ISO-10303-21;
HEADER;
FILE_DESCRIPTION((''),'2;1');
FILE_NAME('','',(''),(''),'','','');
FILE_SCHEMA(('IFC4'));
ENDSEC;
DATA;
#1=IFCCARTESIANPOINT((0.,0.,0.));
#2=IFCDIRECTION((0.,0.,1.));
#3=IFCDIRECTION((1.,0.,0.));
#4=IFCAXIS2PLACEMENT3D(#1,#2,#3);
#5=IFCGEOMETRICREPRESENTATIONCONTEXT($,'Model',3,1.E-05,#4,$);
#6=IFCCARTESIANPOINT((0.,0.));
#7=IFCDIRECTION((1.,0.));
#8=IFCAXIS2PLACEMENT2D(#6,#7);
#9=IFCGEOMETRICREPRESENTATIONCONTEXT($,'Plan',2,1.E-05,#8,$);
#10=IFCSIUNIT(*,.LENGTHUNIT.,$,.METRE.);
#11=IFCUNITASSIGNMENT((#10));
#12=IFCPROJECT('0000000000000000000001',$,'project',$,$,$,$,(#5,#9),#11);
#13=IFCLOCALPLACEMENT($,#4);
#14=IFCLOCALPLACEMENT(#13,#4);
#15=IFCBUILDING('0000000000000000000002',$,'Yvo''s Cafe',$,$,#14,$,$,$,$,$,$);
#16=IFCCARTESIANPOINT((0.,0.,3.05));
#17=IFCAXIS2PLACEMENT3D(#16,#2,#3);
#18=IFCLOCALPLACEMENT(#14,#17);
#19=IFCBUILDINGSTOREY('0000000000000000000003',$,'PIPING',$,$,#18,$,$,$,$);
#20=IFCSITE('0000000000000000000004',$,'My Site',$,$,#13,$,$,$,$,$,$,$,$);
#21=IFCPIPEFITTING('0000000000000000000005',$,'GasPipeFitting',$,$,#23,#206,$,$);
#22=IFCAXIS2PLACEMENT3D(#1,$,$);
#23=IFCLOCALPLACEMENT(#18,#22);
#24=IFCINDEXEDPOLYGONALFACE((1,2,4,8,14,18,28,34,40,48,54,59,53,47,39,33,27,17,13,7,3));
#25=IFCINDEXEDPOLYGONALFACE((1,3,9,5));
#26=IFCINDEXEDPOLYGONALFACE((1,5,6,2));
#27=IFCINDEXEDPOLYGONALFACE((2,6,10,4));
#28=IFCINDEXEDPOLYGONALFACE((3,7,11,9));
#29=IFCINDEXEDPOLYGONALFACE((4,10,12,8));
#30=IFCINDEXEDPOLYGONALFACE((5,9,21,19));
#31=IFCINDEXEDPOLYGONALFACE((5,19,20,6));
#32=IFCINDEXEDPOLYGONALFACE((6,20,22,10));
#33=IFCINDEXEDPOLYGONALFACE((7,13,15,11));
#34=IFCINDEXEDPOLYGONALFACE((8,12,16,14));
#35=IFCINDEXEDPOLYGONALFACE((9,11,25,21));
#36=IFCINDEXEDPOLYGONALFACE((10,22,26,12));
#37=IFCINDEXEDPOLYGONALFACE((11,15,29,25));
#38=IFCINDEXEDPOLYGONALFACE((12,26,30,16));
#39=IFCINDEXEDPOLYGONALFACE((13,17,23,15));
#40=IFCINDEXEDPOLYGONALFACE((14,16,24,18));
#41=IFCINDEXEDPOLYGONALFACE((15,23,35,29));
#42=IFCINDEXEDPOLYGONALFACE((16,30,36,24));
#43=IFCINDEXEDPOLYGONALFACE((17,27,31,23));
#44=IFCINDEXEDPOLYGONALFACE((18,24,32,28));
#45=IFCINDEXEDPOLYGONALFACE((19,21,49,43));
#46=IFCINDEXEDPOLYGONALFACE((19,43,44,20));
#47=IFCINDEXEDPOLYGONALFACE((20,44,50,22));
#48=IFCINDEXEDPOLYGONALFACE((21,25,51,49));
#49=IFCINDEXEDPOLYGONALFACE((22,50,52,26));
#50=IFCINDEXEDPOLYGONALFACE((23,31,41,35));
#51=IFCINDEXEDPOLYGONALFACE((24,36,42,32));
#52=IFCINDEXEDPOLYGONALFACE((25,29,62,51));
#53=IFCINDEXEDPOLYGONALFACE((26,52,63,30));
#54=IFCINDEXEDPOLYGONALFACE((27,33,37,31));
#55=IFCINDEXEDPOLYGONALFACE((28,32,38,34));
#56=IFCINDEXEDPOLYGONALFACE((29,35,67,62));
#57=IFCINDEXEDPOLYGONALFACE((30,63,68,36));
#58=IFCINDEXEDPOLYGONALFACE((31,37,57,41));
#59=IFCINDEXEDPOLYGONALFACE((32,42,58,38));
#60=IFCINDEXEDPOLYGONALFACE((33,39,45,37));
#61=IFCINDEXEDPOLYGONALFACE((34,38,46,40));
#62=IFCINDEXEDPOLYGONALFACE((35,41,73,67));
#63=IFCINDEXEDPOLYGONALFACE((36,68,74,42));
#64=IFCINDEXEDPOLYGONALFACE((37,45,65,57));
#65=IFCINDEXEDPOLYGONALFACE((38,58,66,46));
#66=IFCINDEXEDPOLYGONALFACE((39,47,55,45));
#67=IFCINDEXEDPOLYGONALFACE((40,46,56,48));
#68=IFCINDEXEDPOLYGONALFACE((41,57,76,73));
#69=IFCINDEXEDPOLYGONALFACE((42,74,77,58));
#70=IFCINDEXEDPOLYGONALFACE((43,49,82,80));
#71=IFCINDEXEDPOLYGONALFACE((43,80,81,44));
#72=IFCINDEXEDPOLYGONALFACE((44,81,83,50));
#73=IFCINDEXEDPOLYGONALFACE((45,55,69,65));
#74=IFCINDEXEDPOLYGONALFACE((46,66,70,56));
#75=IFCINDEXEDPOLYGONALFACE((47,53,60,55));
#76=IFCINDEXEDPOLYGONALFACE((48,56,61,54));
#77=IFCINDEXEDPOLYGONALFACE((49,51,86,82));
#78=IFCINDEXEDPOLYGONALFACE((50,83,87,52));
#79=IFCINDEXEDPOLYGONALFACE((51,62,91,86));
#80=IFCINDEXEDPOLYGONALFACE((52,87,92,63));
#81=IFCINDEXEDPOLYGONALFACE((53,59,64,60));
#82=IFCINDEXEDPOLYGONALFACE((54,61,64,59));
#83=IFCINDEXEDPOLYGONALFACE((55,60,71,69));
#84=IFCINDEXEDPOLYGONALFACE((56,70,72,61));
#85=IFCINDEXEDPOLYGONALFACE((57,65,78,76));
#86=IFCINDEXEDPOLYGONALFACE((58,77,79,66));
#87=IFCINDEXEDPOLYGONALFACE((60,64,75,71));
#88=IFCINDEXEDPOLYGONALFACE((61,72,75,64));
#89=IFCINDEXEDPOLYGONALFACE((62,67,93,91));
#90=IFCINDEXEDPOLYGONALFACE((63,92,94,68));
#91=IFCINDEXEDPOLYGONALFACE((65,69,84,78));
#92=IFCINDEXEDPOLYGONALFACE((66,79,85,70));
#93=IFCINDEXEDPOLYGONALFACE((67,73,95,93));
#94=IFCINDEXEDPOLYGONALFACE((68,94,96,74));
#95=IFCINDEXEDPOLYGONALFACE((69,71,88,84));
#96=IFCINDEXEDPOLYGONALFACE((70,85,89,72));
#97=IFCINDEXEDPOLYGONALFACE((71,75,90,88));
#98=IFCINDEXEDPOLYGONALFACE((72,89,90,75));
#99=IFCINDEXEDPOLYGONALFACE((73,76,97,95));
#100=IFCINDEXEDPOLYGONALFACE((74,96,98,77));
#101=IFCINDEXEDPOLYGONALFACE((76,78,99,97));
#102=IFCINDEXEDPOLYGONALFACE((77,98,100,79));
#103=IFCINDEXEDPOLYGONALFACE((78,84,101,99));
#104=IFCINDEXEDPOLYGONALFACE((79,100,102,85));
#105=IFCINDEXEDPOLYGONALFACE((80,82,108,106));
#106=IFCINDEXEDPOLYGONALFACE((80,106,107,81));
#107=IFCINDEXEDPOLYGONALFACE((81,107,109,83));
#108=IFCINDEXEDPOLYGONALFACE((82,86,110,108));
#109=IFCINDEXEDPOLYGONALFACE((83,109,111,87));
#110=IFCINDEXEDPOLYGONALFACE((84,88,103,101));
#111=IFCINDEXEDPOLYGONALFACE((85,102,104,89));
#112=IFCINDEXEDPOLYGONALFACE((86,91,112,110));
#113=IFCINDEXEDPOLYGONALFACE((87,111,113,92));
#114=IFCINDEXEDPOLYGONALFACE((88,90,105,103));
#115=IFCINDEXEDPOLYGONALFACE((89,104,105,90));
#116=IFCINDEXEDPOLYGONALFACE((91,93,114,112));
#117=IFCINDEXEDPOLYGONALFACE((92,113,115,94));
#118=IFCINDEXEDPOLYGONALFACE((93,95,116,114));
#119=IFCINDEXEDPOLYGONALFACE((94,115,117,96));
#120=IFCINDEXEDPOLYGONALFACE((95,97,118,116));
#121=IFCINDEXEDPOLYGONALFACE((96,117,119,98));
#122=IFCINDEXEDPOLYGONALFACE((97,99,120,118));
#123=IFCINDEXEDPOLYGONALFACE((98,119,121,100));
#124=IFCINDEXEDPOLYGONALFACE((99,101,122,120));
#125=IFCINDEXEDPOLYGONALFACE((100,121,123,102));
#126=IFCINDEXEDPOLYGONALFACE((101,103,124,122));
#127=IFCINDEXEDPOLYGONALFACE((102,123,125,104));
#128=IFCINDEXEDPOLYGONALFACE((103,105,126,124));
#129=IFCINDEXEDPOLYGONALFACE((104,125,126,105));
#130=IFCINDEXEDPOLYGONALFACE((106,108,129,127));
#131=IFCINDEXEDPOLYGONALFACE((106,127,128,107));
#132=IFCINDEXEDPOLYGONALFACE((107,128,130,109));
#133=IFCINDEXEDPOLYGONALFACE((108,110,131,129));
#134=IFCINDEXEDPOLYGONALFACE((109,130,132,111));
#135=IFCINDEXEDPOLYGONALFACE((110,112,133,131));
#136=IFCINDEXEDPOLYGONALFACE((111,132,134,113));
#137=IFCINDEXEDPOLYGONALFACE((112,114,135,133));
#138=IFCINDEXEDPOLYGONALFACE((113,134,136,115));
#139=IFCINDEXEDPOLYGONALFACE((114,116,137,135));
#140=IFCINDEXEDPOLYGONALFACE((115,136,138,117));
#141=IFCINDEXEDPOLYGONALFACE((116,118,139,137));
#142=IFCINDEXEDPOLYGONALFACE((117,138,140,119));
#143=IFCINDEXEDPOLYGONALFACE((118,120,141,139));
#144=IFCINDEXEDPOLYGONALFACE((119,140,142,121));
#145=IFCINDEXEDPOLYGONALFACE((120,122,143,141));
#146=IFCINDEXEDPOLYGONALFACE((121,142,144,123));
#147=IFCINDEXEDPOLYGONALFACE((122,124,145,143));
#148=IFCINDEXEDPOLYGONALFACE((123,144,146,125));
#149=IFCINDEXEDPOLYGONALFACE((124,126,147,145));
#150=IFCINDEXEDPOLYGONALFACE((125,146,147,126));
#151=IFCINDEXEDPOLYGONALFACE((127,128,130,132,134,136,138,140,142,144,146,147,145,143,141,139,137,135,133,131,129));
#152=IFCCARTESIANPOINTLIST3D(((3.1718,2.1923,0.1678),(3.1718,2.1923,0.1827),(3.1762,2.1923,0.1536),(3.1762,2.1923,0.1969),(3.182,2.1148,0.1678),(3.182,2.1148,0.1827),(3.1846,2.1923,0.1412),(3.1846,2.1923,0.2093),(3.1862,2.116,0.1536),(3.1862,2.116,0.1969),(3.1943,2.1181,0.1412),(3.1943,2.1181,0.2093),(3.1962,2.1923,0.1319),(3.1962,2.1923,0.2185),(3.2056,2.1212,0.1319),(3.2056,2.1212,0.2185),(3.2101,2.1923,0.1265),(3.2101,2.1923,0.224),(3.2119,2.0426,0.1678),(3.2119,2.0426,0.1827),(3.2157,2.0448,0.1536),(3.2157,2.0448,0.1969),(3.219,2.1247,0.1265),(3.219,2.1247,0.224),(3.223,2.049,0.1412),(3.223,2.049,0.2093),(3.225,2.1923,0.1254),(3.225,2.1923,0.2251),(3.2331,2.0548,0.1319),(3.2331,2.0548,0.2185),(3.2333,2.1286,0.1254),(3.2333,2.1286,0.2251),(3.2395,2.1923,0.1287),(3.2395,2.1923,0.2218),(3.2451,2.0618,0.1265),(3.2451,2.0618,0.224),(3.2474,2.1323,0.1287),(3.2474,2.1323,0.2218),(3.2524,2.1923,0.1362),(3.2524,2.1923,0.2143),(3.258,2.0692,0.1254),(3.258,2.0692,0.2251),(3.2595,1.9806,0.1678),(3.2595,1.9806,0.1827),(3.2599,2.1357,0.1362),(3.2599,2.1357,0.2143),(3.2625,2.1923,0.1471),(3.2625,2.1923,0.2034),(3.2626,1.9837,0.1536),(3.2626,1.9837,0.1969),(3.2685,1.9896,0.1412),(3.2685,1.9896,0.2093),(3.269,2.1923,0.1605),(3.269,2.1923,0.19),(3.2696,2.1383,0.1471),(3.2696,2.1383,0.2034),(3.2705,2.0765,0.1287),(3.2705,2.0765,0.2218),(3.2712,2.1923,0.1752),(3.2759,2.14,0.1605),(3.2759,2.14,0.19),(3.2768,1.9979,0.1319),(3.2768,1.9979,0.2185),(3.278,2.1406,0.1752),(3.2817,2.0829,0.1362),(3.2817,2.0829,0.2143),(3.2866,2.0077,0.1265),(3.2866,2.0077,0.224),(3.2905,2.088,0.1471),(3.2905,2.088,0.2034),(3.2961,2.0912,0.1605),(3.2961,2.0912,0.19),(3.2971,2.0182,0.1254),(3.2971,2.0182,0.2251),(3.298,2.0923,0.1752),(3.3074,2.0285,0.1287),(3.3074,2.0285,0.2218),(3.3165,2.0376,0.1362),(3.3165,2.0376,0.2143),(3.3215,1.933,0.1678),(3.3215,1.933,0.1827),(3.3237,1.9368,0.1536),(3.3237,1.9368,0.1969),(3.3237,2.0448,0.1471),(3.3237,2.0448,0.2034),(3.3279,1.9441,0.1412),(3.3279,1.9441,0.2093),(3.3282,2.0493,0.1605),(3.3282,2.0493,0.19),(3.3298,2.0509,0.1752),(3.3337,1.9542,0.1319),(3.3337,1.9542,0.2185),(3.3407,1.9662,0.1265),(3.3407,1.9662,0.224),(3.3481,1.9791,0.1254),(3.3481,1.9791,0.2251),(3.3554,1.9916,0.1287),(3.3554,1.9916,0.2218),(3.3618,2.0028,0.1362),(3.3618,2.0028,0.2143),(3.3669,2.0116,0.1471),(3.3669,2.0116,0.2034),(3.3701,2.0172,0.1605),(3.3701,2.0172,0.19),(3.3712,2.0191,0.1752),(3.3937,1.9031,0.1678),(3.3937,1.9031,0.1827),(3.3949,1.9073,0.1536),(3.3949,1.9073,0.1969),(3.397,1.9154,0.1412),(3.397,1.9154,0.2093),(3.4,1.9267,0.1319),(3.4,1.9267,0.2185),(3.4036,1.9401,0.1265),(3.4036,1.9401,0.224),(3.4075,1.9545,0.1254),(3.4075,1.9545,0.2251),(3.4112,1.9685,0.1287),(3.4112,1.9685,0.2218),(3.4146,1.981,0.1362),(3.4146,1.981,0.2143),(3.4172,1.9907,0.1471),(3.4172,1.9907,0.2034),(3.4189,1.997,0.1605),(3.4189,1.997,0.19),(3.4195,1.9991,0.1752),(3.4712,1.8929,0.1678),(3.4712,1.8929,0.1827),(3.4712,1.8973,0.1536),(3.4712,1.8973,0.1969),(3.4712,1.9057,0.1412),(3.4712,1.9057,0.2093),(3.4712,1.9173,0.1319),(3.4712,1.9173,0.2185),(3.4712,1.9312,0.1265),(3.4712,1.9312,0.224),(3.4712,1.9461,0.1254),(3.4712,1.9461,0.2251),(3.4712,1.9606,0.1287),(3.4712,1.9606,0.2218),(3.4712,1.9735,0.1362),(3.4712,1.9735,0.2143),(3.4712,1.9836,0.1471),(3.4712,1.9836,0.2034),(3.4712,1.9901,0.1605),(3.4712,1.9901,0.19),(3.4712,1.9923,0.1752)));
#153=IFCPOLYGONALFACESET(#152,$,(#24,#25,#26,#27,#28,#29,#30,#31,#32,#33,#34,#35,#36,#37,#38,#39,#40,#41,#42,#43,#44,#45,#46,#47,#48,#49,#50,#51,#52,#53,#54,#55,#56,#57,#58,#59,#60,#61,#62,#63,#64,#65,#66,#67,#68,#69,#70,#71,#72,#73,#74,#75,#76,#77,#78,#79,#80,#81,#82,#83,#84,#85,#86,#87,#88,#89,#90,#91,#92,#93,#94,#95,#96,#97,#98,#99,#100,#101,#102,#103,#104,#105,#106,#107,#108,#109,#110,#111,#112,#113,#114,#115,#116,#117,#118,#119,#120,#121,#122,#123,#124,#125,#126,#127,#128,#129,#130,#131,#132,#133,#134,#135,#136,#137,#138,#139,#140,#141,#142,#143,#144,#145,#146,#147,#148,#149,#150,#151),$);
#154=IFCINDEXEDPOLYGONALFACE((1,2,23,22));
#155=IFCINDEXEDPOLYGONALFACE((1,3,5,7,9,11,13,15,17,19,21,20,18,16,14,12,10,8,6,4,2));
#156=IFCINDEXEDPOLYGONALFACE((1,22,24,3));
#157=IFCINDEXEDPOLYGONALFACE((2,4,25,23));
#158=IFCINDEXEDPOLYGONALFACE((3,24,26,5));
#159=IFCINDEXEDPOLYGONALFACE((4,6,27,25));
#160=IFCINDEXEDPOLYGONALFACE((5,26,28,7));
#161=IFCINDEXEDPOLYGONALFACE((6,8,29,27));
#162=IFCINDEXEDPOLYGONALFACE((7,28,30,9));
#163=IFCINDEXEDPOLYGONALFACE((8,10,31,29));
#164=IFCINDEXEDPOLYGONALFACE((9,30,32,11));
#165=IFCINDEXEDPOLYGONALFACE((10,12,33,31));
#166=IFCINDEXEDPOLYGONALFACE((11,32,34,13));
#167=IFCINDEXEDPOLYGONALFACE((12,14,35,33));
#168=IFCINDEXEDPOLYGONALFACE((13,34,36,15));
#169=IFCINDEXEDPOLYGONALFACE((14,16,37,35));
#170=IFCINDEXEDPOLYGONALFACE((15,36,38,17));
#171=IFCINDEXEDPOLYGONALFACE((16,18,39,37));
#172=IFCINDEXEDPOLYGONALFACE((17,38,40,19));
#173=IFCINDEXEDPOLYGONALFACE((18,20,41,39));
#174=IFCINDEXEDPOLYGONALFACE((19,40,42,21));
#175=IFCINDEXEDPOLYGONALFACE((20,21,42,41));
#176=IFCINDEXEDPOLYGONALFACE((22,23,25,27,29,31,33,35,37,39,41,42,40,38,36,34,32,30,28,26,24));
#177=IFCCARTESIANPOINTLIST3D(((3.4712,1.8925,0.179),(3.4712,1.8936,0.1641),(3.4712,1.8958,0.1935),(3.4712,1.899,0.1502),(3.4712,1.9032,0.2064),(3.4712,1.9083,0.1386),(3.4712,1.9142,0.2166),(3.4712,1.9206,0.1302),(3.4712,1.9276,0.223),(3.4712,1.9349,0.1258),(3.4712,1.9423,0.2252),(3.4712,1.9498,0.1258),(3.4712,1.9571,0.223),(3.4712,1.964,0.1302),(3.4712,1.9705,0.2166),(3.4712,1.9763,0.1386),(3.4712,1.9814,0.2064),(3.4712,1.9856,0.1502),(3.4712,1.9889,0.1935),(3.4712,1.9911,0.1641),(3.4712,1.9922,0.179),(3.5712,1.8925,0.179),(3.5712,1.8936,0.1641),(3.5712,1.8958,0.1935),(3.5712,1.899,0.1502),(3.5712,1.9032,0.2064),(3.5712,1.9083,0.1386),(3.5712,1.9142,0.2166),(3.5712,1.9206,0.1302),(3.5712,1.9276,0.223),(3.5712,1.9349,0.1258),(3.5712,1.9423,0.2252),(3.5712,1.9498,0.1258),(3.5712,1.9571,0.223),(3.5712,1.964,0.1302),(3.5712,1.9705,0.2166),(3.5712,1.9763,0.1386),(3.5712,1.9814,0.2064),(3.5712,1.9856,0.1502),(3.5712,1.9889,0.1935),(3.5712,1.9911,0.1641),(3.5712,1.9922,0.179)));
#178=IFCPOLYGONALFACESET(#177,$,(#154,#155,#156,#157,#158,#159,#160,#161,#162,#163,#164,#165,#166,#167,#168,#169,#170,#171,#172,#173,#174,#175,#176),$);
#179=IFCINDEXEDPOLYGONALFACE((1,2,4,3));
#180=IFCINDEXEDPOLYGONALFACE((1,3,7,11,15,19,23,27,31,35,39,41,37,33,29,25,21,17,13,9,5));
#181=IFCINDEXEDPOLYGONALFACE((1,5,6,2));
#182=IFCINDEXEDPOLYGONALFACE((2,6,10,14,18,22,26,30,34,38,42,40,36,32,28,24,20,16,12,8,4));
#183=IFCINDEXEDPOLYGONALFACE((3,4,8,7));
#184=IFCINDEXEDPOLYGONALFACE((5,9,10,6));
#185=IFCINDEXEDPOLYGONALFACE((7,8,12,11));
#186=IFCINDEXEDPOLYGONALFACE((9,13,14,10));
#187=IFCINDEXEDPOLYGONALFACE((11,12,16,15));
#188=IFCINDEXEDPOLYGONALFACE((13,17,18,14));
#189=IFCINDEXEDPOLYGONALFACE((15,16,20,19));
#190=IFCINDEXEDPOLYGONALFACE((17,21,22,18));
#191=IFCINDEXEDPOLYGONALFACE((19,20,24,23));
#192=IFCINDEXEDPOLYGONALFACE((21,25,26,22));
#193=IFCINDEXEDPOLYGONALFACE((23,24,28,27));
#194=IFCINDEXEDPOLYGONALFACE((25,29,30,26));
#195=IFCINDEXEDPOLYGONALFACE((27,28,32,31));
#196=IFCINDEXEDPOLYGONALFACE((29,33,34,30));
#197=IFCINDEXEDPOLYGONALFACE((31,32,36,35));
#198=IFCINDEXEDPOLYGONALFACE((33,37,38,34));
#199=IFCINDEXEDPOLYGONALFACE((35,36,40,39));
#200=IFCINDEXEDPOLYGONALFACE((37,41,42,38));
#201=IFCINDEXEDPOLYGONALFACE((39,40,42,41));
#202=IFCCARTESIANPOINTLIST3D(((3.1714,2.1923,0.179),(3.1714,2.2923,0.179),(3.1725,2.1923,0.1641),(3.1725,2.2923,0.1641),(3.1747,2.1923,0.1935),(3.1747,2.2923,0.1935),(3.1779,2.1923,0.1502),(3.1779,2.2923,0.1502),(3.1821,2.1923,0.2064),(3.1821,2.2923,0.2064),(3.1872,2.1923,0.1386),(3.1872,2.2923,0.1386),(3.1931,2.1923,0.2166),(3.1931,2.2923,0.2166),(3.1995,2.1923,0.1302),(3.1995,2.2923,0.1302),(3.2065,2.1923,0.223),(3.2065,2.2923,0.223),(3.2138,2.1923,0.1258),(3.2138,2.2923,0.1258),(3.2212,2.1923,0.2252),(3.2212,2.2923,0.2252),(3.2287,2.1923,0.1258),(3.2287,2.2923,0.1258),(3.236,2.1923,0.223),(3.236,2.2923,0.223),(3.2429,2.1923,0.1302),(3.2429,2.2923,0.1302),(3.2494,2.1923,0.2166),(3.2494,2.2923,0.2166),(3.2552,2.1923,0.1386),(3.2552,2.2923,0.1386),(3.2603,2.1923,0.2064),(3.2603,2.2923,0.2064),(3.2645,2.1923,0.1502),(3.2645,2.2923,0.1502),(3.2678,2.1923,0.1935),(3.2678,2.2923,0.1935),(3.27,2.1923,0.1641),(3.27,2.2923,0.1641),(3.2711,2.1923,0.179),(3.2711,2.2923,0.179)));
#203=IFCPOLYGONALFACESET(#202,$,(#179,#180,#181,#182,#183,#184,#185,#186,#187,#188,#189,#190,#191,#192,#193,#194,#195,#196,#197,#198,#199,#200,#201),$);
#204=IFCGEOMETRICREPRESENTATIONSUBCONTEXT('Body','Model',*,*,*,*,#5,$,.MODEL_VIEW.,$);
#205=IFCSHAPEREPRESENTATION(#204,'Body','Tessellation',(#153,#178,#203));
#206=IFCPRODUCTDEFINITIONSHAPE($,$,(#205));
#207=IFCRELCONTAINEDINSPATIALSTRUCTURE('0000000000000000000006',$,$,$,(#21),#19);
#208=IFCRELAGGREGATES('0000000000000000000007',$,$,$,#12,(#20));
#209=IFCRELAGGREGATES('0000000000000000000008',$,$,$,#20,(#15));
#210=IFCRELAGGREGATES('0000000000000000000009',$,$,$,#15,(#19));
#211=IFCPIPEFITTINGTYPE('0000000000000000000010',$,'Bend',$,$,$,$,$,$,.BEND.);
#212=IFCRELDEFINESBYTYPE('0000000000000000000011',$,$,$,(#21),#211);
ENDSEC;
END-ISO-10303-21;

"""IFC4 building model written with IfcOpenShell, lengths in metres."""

from ifc_helpers import new_model, entity, si_unit, frame, origin_with_axes, origin_2d_with_axis, place, context, subcontext, project, spatial, circle, extrude, source, transform, mapped, type_object, type_shapes, element, save


model = new_model("IFC4")

# Units and contexts
model_context = context("Model", 3, precision=1e-05, world=origin_with_axes())
plan_context = context("Plan", 2, precision=1e-05, world=origin_2d_with_axis())
body_context = subcontext(model_context, "Body", "Model", "MODEL_VIEW")
ifc_project = project(units=[si_unit("LENGTHUNIT", "METRE")], contexts=[model_context, plan_context])

# Site, building, storey
site_placement = place(None, origin_with_axes())
site = spatial("IfcSite", under=ifc_project, at=site_placement, Name="My Site")
building_placement = place(site_placement, origin_with_axes())
building = spatial("IfcBuilding", under=site, at=building_placement, Name="Yvo's Cafe")
storey_placement = place(building_placement, frame((0.0, 0.0, 3.05), z_axis=(0.0, 0.0, 1.0), x_axis=(1.0, 0.0, 0.0)))
storey = spatial("IfcBuildingStorey", under=building, at=storey_placement, Name="PIPING")

# Shared definitions
pipe_fitting_type_1 = type_object("IfcPipeFittingType", Name="Bend", PredefinedType="BEND")
shared_shape_1 = source(origin_with_axes(), body_context, "Body", "SolidModel", [
    entity("IfcSweptDiskSolid", entity("IfcIndexedPolyCurve", entity("IfcCartesianPointList3D", [[0.0, 0.0, -0.1], [0.0, -0.0732, -0.2768], [0.0, -0.25, -0.35]]), [entity("IfcArcIndex", [1, 2, 3])]), 0.05),
    extrude(circle(Radius=0.05), origin_with_axes(), (0.0, 0.0, -1.0), 0.1),
    extrude(circle(Radius=0.05), frame((0.0, -0.25, -0.35), z_axis=(0.0, -1.0, 0.0), x_axis=(1.0, 0.0, 0.0)), (0.0, 0.0, 1.0), 0.1),
])
type_shapes(pipe_fitting_type_1, [shared_shape_1])

# Pipe fitting
for number, where, z_axis, x_axis, name in (
    (1, (3.5712, 1.9423, 0.1752), (1.0, 0.0, 0.0), (0.0, 0.0, 1.0), "GasPipeFitting"),
):
    element("IfcPipeFitting", number, at=place(storey_placement, frame(where, z_axis=z_axis, x_axis=x_axis)), inside=storey, type_object=pipe_fitting_type_1, Name=name, context=body_context, shape_type="MappedRepresentation", body=[
        mapped(shared_shape_1, transform((0.0, 0.0, 0.0), x_axis=(1.0, 0.0, 0.0), y_axis=(0.0, 1.0, 0.0), z_axis=(0.0, 0.0, 1.0), scale=1.0)),
    ])

save(model, "model.ifc")
